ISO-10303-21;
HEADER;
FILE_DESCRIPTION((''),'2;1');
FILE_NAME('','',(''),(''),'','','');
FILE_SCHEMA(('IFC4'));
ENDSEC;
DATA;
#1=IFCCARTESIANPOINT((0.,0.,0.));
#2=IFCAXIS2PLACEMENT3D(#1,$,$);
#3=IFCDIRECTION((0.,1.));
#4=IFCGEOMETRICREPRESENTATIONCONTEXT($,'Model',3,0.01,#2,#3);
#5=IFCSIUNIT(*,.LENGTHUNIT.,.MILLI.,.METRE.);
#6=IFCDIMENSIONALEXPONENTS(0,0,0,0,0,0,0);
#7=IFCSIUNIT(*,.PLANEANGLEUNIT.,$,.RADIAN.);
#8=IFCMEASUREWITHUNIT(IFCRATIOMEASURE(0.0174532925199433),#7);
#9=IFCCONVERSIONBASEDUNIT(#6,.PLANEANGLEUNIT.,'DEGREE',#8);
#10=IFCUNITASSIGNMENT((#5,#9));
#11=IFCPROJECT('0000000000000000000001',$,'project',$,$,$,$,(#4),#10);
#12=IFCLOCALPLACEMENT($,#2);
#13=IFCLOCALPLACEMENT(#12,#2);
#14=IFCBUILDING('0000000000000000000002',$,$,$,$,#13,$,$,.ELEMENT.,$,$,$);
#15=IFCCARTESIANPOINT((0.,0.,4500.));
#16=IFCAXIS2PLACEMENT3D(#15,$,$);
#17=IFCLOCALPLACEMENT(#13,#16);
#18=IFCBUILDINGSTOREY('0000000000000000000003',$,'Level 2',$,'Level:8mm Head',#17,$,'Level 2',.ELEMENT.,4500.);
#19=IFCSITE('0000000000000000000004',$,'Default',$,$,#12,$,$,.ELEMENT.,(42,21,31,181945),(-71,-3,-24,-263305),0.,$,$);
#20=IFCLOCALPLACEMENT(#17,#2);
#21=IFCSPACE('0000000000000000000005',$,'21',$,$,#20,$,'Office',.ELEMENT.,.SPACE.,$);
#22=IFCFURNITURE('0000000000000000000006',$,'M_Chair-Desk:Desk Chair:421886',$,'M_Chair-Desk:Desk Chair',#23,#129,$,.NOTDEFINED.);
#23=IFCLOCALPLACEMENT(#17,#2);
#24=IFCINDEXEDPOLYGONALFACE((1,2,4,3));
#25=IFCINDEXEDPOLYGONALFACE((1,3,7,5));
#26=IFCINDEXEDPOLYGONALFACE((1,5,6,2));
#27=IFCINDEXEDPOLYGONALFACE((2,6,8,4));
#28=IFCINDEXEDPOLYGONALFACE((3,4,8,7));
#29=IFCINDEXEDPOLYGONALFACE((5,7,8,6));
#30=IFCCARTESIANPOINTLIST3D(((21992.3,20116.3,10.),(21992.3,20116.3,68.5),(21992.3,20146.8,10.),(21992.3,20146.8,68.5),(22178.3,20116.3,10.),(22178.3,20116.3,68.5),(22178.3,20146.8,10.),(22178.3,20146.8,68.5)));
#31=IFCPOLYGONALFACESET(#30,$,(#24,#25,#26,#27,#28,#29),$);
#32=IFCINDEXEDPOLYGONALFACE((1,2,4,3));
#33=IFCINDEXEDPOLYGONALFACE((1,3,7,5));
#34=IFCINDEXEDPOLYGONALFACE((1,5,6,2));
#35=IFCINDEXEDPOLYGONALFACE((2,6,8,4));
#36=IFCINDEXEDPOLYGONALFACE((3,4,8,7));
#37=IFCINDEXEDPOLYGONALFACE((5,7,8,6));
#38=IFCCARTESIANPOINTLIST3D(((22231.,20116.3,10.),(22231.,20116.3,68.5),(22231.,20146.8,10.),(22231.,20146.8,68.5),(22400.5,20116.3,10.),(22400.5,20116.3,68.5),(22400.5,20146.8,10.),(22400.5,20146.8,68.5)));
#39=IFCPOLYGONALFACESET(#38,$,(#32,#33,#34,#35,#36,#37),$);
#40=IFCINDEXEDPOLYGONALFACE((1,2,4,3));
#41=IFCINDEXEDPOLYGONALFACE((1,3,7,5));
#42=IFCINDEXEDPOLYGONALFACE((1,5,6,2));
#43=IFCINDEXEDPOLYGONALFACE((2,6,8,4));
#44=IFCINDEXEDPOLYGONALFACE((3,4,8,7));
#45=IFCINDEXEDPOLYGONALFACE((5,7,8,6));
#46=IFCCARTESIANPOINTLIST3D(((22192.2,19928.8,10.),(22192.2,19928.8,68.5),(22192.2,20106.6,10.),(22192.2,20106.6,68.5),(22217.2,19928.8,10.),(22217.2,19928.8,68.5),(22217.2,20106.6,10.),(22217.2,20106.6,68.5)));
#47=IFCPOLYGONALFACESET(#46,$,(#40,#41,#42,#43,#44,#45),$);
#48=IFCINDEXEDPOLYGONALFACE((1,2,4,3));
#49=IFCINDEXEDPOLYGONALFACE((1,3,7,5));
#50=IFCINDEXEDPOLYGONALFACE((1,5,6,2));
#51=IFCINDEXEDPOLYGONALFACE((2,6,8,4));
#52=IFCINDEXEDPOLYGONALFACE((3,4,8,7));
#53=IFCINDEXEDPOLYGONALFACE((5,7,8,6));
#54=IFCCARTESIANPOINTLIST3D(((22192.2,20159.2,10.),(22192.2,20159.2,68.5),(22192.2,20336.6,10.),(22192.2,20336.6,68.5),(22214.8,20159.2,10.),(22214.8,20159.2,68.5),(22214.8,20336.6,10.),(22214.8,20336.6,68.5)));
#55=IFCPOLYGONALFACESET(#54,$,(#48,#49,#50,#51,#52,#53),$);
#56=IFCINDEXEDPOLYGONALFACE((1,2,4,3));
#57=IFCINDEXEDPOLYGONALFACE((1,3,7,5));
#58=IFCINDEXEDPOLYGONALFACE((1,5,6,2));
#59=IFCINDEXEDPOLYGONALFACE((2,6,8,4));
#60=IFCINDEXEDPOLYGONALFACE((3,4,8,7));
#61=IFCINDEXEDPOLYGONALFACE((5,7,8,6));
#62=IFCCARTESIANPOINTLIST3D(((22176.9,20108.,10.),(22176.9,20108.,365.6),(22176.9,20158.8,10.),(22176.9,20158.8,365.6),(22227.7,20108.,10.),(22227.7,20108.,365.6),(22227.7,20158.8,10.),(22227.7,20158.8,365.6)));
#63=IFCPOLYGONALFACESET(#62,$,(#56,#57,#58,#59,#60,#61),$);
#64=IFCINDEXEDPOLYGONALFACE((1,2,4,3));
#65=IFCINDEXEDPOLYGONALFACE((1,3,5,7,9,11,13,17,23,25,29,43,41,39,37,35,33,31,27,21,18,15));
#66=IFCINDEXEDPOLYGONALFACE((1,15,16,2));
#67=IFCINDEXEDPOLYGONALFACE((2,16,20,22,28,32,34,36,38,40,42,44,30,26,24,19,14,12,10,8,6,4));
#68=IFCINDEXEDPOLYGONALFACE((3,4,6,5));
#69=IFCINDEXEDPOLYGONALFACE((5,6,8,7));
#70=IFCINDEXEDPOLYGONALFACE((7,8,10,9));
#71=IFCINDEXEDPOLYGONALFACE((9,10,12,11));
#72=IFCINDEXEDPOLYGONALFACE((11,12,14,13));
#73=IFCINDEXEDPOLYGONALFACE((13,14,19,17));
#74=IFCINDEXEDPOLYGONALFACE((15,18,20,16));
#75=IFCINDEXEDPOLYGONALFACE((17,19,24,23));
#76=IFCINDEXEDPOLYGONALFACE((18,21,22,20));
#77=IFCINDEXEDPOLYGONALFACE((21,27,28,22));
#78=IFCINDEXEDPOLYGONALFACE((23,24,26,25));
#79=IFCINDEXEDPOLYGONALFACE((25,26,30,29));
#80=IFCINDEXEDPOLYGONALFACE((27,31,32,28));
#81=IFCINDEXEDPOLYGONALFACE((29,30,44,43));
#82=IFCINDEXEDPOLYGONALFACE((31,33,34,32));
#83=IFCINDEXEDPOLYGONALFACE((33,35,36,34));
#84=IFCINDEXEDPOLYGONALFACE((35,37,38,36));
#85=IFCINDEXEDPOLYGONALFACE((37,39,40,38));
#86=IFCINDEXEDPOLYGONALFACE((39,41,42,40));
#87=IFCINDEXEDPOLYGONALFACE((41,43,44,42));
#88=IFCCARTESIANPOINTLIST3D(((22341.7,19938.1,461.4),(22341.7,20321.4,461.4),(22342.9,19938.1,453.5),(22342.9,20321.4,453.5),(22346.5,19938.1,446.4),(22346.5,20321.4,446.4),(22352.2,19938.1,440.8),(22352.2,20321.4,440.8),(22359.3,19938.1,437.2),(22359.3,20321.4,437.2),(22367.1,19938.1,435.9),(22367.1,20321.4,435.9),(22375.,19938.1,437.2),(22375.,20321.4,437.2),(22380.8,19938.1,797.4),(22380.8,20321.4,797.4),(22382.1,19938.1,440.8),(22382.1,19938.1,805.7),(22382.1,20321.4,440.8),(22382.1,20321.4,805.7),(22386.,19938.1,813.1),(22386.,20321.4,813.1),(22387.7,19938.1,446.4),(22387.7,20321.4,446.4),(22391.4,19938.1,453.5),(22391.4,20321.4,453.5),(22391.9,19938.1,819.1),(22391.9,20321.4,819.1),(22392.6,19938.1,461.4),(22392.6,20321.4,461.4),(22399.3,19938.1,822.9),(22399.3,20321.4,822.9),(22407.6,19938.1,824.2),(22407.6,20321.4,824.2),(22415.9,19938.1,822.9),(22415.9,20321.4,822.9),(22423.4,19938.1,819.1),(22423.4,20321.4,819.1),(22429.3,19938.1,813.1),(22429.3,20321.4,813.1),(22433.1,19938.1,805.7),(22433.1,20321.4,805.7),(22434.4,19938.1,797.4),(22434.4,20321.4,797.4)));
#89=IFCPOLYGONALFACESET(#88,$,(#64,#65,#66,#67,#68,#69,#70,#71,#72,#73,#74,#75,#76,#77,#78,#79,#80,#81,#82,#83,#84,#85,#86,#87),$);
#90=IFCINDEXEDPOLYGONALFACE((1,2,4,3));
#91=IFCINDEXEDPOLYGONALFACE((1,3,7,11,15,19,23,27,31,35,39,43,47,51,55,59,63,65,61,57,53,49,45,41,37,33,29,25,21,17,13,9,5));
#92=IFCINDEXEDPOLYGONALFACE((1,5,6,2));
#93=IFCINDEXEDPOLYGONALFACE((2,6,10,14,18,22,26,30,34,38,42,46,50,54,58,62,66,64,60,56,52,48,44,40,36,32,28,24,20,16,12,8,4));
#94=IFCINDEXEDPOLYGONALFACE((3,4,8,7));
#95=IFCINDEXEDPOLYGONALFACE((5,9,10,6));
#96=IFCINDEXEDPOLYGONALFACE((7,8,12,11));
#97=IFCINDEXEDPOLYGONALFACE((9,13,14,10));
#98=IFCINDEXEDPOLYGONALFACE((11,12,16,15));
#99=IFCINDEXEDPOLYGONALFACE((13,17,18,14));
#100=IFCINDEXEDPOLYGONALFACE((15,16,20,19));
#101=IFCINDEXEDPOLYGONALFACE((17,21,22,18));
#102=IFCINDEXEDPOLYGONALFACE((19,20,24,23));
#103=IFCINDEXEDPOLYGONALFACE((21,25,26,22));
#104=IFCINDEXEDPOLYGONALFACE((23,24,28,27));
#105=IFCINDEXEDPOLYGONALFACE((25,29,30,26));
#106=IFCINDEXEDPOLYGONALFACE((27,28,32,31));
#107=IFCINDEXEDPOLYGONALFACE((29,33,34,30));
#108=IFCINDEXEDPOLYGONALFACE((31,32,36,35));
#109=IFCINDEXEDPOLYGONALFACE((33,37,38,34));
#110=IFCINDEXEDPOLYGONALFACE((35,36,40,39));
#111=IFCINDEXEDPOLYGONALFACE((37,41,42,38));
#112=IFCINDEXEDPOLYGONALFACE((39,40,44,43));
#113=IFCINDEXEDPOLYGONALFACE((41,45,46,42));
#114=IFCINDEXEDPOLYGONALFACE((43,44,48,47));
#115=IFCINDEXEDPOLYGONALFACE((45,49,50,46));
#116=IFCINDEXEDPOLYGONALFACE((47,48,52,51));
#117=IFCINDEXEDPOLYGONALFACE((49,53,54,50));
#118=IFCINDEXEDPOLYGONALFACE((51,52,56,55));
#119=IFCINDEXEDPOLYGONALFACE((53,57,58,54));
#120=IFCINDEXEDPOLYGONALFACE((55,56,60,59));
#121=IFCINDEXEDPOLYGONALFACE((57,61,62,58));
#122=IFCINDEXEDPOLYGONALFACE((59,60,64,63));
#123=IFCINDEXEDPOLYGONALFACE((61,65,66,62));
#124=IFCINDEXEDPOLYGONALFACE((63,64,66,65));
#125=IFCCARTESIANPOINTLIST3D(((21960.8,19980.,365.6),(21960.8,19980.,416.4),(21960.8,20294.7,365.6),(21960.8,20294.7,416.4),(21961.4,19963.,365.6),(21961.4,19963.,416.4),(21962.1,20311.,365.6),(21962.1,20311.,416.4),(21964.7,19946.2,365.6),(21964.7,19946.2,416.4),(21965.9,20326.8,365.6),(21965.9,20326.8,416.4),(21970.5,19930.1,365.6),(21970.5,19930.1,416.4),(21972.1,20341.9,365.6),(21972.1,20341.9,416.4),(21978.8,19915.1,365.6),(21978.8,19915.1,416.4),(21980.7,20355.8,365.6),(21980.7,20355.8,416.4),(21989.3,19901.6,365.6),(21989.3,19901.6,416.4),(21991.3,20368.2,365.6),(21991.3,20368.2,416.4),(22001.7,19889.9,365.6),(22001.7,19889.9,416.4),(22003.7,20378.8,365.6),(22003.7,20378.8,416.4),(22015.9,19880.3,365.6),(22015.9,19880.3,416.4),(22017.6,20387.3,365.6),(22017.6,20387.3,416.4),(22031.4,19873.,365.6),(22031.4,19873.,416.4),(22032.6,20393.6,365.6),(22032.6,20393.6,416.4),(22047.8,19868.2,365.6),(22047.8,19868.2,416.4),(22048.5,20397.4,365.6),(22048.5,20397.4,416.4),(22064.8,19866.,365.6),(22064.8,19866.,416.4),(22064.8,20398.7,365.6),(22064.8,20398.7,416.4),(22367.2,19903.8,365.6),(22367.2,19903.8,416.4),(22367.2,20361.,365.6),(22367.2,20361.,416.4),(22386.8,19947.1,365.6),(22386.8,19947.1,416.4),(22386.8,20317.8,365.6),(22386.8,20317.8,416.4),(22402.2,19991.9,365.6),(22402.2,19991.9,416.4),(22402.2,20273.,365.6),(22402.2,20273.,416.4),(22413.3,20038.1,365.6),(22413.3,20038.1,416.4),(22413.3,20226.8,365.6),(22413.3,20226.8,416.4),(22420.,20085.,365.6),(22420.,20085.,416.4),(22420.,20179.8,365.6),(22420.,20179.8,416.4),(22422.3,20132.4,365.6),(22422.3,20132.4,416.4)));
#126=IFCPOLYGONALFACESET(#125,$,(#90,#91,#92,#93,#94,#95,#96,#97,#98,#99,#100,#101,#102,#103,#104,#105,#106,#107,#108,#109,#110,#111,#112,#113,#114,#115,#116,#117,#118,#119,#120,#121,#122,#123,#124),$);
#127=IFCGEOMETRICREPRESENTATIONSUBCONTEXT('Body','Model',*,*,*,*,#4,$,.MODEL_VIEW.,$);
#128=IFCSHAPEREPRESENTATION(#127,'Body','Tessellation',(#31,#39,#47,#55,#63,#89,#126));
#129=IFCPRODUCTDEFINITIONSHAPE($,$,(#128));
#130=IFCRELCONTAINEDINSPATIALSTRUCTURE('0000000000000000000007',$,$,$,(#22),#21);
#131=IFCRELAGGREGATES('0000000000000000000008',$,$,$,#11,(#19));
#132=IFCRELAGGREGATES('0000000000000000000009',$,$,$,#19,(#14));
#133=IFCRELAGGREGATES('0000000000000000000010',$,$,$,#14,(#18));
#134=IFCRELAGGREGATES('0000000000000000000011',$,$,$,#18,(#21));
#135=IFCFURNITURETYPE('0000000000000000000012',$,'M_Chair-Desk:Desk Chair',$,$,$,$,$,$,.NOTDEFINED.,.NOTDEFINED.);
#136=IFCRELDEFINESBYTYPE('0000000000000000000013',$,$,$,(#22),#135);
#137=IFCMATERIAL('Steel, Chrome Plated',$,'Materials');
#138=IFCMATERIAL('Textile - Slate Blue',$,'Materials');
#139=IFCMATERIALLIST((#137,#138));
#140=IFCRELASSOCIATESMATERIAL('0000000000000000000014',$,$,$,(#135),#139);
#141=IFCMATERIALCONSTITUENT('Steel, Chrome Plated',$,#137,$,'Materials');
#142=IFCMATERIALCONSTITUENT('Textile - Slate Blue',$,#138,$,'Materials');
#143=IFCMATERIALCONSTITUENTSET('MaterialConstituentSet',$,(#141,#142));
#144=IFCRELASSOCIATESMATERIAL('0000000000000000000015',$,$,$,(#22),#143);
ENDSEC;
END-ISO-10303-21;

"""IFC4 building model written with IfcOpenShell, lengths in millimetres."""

from ifc_helpers import new_model, entity, si_unit, converted_unit, direction, frame, origin, place, context, subcontext, project, spatial, indexed_curve, outline, extrude, source, transform, mapped, material, material_list, constituent, constituent_set, type_object, type_shapes, element, save


model = new_model("IFC4")

# Units and contexts
model_context = context("Model", 3, precision=0.01, world=origin(), true_north=direction((0.0, 1.0)))
body_context = subcontext(model_context, "Body", "Model", "MODEL_VIEW")
ifc_project = project(units=[si_unit("LENGTHUNIT", "METRE", prefix="MILLI"), converted_unit("PLANEANGLEUNIT", "DEGREE", entity("IfcRatioMeasure", 0.0174532925199433), si_unit("PLANEANGLEUNIT", "RADIAN"), dimensions=[0, 0, 0, 0, 0, 0, 0])], contexts=[model_context])

# Site, building, storey
site_placement = place(None, origin())
site = spatial("IfcSite", under=ifc_project, at=site_placement, Name="Default", CompositionType="ELEMENT", RefLatitude=(42, 21, 31, 181945), RefLongitude=(-71, -3, -24, -263305), RefElevation=0.0)
building_placement = place(site_placement, origin())
building = spatial("IfcBuilding", under=site, at=building_placement, CompositionType="ELEMENT")
storey_placement = place(building_placement, frame((0.0, 0.0, 4500.0)))
storey = spatial("IfcBuildingStorey", under=building, at=storey_placement, Name="Level 2", ObjectType="Level:8mm Head", LongName="Level 2", CompositionType="ELEMENT", Elevation=4500.0)

# Shared definitions
space_placement = place(storey_placement, origin())
space = spatial("IfcSpace", under=storey, at=space_placement, Name="21", LongName="Office", CompositionType="ELEMENT", PredefinedType="SPACE")

# Furniture
ifc_material_1 = material(Name="Steel, Chrome Plated", Category="Materials")
ifc_material_2 = material(Name="Textile - Slate Blue", Category="Materials")
ifc_material_list_1 = material_list([ifc_material_1, ifc_material_2])
furniture_type = type_object("IfcFurnitureType", Name="M_Chair-Desk:Desk Chair", AssemblyPlace="NOTDEFINED", PredefinedType="NOTDEFINED", material=ifc_material_list_1)
shared_shape_1 = source(origin(), body_context, "Body", "SweptSolid", [
    extrude(outline(indexed_curve([(-15.2, -93.0), (15.2, -93.0), (15.2, 93.0), (-15.2, 93.0), (-15.2, -93.0)], self_intersect=False)), frame((-0.9, 281.9, 0.0)), (0.0, 0.0, 1.0), 58.5),
    extrude(outline(indexed_curve([(-15.2, -84.7), (15.2, -84.7), (15.2, 84.7), (-15.2, 84.7), (-15.2, -84.7)], self_intersect=False)), frame((-0.9, 51.5, 0.0), z_axis=(0.0, 0.0, 1.0), x_axis=(-1.0, 0.0, 0.0)), (0.0, 0.0, 1.0), 58.5),
    extrude(outline(indexed_curve([(-12.5, -88.9), (12.5, -88.9), (12.5, 88.9), (-12.5, 88.9), (-12.5, -88.9)], self_intersect=False)), frame((-114.8, 162.5, 0.0), z_axis=(0.0, 0.0, 1.0), x_axis=(0.0, -1.0, 0.0)), (0.0, 0.0, 1.0), 58.5),
    extrude(outline(indexed_curve([(-88.7, -11.3), (88.7, -11.3), (88.7, 11.3), (-88.7, 11.3), (-88.7, -11.3)], self_intersect=False)), frame((115.5, 163.7, 0.0), z_axis=(0.0, 0.0, 1.0), x_axis=(-1.0, 0.0, 0.0)), (0.0, 0.0, 1.0), 58.5),
    extrude(outline(indexed_curve([(-25.4, -25.4), (25.4, -25.4), (25.4, 25.4), (-25.4, 25.4), (-25.4, -25.4)], self_intersect=False)), frame((0.9, 164.9, 0.0), z_axis=(0.0, 0.0, 1.0), x_axis=(-1.0, 0.0, 0.0)), (0.0, 0.0, 1.0), 355.6),
    extrude(outline(indexed_curve([(6.5, 168.0), (5.2, 176.3), (1.4, 183.8), (-4.5, 189.7), (-12.0, 193.5), (-20.2, 194.8), (-28.5, 193.5), (-36.0, 189.7), (-41.9, 183.8), (-45.7, 176.3), (-47.0, 168.0), (-5.2, -168.0), (-4.0, -175.9), (-0.4, -183.0), (5.3, -188.6), (12.4, -192.2), (20.2, -193.5), (28.1, -192.2), (35.2, -188.6), (40.9, -183.0), (44.5, -175.9), (45.7, -168.0), (6.5, 168.0)], self_intersect=False)), frame((-194.4, -20.2, 619.4), z_axis=(1.0, 0.0, 0.0), x_axis=(0.0, 1.0, 0.0)), (0.0, 0.0, 1.0), 383.3),
    extrude(outline(indexed_curve([(-98.9, -257.7), (205.9, -257.7), (230.7, -217.3), (251.6, -174.7), (268.3, -130.3), (280.8, -84.5), (288.9, -37.7), (292.6, 9.6), (291.7, 57.0), (286.4, 104.2), (276.7, 150.6), (262.6, 195.9), (-32.8, 270.8), (-49.1, 271.5), (-65.3, 269.7), (-81.1, 265.4), (-95.9, 258.6), (-109.5, 249.7), (-121.6, 238.7), (-131.8, 225.9), (-139.8, 211.7), (-145.6, 196.5), (-148.9, 180.5), (-187.9, -131.7), (-189.4, -148.8), (-188.3, -165.8), (-184.5, -182.5), (-178.1, -198.4), (-169.4, -213.1), (-158.5, -226.2), (-145.6, -237.5), (-131.2, -246.7), (-115.5, -253.5), (-98.9, -257.7)], self_intersect=False)), frame((1.6, 236.3, 355.6), z_axis=(0.0, 0.0, 1.0), x_axis=(0.124035, -0.992278, 0.0)), (0.0, 0.0, 1.0), 50.8),
])
type_shapes(furniture_type, [shared_shape_1])
ifc_constituent_1 = constituent(ifc_material_1, Name="Steel, Chrome Plated", Category="Materials")
ifc_constituent_2 = constituent(ifc_material_2, Name="Textile - Slate Blue", Category="Materials")
ifc_constituent_set_1 = constituent_set(constituents=[ifc_constituent_1, ifc_constituent_2], Name="MaterialConstituentSet")
furniture_1_placement = place(space_placement, frame((22367.2, 20132.4, 10.0), z_axis=(0.0, 0.0, 1.0), x_axis=(0.0, 1.0, 0.0)))
element("IfcFurniture", 1, at=furniture_1_placement, inside=space, type_object=furniture_type, material=ifc_constituent_set_1, Name="M_Chair-Desk:Desk Chair:421886", ObjectType="M_Chair-Desk:Desk Chair", PredefinedType="NOTDEFINED", context=body_context, shape_type="MappedRepresentation", body=[
    mapped(shared_shape_1, transform((0.0, 0.0, 0.0), scale=1.0)),
])

save(model, "model.ifc")
